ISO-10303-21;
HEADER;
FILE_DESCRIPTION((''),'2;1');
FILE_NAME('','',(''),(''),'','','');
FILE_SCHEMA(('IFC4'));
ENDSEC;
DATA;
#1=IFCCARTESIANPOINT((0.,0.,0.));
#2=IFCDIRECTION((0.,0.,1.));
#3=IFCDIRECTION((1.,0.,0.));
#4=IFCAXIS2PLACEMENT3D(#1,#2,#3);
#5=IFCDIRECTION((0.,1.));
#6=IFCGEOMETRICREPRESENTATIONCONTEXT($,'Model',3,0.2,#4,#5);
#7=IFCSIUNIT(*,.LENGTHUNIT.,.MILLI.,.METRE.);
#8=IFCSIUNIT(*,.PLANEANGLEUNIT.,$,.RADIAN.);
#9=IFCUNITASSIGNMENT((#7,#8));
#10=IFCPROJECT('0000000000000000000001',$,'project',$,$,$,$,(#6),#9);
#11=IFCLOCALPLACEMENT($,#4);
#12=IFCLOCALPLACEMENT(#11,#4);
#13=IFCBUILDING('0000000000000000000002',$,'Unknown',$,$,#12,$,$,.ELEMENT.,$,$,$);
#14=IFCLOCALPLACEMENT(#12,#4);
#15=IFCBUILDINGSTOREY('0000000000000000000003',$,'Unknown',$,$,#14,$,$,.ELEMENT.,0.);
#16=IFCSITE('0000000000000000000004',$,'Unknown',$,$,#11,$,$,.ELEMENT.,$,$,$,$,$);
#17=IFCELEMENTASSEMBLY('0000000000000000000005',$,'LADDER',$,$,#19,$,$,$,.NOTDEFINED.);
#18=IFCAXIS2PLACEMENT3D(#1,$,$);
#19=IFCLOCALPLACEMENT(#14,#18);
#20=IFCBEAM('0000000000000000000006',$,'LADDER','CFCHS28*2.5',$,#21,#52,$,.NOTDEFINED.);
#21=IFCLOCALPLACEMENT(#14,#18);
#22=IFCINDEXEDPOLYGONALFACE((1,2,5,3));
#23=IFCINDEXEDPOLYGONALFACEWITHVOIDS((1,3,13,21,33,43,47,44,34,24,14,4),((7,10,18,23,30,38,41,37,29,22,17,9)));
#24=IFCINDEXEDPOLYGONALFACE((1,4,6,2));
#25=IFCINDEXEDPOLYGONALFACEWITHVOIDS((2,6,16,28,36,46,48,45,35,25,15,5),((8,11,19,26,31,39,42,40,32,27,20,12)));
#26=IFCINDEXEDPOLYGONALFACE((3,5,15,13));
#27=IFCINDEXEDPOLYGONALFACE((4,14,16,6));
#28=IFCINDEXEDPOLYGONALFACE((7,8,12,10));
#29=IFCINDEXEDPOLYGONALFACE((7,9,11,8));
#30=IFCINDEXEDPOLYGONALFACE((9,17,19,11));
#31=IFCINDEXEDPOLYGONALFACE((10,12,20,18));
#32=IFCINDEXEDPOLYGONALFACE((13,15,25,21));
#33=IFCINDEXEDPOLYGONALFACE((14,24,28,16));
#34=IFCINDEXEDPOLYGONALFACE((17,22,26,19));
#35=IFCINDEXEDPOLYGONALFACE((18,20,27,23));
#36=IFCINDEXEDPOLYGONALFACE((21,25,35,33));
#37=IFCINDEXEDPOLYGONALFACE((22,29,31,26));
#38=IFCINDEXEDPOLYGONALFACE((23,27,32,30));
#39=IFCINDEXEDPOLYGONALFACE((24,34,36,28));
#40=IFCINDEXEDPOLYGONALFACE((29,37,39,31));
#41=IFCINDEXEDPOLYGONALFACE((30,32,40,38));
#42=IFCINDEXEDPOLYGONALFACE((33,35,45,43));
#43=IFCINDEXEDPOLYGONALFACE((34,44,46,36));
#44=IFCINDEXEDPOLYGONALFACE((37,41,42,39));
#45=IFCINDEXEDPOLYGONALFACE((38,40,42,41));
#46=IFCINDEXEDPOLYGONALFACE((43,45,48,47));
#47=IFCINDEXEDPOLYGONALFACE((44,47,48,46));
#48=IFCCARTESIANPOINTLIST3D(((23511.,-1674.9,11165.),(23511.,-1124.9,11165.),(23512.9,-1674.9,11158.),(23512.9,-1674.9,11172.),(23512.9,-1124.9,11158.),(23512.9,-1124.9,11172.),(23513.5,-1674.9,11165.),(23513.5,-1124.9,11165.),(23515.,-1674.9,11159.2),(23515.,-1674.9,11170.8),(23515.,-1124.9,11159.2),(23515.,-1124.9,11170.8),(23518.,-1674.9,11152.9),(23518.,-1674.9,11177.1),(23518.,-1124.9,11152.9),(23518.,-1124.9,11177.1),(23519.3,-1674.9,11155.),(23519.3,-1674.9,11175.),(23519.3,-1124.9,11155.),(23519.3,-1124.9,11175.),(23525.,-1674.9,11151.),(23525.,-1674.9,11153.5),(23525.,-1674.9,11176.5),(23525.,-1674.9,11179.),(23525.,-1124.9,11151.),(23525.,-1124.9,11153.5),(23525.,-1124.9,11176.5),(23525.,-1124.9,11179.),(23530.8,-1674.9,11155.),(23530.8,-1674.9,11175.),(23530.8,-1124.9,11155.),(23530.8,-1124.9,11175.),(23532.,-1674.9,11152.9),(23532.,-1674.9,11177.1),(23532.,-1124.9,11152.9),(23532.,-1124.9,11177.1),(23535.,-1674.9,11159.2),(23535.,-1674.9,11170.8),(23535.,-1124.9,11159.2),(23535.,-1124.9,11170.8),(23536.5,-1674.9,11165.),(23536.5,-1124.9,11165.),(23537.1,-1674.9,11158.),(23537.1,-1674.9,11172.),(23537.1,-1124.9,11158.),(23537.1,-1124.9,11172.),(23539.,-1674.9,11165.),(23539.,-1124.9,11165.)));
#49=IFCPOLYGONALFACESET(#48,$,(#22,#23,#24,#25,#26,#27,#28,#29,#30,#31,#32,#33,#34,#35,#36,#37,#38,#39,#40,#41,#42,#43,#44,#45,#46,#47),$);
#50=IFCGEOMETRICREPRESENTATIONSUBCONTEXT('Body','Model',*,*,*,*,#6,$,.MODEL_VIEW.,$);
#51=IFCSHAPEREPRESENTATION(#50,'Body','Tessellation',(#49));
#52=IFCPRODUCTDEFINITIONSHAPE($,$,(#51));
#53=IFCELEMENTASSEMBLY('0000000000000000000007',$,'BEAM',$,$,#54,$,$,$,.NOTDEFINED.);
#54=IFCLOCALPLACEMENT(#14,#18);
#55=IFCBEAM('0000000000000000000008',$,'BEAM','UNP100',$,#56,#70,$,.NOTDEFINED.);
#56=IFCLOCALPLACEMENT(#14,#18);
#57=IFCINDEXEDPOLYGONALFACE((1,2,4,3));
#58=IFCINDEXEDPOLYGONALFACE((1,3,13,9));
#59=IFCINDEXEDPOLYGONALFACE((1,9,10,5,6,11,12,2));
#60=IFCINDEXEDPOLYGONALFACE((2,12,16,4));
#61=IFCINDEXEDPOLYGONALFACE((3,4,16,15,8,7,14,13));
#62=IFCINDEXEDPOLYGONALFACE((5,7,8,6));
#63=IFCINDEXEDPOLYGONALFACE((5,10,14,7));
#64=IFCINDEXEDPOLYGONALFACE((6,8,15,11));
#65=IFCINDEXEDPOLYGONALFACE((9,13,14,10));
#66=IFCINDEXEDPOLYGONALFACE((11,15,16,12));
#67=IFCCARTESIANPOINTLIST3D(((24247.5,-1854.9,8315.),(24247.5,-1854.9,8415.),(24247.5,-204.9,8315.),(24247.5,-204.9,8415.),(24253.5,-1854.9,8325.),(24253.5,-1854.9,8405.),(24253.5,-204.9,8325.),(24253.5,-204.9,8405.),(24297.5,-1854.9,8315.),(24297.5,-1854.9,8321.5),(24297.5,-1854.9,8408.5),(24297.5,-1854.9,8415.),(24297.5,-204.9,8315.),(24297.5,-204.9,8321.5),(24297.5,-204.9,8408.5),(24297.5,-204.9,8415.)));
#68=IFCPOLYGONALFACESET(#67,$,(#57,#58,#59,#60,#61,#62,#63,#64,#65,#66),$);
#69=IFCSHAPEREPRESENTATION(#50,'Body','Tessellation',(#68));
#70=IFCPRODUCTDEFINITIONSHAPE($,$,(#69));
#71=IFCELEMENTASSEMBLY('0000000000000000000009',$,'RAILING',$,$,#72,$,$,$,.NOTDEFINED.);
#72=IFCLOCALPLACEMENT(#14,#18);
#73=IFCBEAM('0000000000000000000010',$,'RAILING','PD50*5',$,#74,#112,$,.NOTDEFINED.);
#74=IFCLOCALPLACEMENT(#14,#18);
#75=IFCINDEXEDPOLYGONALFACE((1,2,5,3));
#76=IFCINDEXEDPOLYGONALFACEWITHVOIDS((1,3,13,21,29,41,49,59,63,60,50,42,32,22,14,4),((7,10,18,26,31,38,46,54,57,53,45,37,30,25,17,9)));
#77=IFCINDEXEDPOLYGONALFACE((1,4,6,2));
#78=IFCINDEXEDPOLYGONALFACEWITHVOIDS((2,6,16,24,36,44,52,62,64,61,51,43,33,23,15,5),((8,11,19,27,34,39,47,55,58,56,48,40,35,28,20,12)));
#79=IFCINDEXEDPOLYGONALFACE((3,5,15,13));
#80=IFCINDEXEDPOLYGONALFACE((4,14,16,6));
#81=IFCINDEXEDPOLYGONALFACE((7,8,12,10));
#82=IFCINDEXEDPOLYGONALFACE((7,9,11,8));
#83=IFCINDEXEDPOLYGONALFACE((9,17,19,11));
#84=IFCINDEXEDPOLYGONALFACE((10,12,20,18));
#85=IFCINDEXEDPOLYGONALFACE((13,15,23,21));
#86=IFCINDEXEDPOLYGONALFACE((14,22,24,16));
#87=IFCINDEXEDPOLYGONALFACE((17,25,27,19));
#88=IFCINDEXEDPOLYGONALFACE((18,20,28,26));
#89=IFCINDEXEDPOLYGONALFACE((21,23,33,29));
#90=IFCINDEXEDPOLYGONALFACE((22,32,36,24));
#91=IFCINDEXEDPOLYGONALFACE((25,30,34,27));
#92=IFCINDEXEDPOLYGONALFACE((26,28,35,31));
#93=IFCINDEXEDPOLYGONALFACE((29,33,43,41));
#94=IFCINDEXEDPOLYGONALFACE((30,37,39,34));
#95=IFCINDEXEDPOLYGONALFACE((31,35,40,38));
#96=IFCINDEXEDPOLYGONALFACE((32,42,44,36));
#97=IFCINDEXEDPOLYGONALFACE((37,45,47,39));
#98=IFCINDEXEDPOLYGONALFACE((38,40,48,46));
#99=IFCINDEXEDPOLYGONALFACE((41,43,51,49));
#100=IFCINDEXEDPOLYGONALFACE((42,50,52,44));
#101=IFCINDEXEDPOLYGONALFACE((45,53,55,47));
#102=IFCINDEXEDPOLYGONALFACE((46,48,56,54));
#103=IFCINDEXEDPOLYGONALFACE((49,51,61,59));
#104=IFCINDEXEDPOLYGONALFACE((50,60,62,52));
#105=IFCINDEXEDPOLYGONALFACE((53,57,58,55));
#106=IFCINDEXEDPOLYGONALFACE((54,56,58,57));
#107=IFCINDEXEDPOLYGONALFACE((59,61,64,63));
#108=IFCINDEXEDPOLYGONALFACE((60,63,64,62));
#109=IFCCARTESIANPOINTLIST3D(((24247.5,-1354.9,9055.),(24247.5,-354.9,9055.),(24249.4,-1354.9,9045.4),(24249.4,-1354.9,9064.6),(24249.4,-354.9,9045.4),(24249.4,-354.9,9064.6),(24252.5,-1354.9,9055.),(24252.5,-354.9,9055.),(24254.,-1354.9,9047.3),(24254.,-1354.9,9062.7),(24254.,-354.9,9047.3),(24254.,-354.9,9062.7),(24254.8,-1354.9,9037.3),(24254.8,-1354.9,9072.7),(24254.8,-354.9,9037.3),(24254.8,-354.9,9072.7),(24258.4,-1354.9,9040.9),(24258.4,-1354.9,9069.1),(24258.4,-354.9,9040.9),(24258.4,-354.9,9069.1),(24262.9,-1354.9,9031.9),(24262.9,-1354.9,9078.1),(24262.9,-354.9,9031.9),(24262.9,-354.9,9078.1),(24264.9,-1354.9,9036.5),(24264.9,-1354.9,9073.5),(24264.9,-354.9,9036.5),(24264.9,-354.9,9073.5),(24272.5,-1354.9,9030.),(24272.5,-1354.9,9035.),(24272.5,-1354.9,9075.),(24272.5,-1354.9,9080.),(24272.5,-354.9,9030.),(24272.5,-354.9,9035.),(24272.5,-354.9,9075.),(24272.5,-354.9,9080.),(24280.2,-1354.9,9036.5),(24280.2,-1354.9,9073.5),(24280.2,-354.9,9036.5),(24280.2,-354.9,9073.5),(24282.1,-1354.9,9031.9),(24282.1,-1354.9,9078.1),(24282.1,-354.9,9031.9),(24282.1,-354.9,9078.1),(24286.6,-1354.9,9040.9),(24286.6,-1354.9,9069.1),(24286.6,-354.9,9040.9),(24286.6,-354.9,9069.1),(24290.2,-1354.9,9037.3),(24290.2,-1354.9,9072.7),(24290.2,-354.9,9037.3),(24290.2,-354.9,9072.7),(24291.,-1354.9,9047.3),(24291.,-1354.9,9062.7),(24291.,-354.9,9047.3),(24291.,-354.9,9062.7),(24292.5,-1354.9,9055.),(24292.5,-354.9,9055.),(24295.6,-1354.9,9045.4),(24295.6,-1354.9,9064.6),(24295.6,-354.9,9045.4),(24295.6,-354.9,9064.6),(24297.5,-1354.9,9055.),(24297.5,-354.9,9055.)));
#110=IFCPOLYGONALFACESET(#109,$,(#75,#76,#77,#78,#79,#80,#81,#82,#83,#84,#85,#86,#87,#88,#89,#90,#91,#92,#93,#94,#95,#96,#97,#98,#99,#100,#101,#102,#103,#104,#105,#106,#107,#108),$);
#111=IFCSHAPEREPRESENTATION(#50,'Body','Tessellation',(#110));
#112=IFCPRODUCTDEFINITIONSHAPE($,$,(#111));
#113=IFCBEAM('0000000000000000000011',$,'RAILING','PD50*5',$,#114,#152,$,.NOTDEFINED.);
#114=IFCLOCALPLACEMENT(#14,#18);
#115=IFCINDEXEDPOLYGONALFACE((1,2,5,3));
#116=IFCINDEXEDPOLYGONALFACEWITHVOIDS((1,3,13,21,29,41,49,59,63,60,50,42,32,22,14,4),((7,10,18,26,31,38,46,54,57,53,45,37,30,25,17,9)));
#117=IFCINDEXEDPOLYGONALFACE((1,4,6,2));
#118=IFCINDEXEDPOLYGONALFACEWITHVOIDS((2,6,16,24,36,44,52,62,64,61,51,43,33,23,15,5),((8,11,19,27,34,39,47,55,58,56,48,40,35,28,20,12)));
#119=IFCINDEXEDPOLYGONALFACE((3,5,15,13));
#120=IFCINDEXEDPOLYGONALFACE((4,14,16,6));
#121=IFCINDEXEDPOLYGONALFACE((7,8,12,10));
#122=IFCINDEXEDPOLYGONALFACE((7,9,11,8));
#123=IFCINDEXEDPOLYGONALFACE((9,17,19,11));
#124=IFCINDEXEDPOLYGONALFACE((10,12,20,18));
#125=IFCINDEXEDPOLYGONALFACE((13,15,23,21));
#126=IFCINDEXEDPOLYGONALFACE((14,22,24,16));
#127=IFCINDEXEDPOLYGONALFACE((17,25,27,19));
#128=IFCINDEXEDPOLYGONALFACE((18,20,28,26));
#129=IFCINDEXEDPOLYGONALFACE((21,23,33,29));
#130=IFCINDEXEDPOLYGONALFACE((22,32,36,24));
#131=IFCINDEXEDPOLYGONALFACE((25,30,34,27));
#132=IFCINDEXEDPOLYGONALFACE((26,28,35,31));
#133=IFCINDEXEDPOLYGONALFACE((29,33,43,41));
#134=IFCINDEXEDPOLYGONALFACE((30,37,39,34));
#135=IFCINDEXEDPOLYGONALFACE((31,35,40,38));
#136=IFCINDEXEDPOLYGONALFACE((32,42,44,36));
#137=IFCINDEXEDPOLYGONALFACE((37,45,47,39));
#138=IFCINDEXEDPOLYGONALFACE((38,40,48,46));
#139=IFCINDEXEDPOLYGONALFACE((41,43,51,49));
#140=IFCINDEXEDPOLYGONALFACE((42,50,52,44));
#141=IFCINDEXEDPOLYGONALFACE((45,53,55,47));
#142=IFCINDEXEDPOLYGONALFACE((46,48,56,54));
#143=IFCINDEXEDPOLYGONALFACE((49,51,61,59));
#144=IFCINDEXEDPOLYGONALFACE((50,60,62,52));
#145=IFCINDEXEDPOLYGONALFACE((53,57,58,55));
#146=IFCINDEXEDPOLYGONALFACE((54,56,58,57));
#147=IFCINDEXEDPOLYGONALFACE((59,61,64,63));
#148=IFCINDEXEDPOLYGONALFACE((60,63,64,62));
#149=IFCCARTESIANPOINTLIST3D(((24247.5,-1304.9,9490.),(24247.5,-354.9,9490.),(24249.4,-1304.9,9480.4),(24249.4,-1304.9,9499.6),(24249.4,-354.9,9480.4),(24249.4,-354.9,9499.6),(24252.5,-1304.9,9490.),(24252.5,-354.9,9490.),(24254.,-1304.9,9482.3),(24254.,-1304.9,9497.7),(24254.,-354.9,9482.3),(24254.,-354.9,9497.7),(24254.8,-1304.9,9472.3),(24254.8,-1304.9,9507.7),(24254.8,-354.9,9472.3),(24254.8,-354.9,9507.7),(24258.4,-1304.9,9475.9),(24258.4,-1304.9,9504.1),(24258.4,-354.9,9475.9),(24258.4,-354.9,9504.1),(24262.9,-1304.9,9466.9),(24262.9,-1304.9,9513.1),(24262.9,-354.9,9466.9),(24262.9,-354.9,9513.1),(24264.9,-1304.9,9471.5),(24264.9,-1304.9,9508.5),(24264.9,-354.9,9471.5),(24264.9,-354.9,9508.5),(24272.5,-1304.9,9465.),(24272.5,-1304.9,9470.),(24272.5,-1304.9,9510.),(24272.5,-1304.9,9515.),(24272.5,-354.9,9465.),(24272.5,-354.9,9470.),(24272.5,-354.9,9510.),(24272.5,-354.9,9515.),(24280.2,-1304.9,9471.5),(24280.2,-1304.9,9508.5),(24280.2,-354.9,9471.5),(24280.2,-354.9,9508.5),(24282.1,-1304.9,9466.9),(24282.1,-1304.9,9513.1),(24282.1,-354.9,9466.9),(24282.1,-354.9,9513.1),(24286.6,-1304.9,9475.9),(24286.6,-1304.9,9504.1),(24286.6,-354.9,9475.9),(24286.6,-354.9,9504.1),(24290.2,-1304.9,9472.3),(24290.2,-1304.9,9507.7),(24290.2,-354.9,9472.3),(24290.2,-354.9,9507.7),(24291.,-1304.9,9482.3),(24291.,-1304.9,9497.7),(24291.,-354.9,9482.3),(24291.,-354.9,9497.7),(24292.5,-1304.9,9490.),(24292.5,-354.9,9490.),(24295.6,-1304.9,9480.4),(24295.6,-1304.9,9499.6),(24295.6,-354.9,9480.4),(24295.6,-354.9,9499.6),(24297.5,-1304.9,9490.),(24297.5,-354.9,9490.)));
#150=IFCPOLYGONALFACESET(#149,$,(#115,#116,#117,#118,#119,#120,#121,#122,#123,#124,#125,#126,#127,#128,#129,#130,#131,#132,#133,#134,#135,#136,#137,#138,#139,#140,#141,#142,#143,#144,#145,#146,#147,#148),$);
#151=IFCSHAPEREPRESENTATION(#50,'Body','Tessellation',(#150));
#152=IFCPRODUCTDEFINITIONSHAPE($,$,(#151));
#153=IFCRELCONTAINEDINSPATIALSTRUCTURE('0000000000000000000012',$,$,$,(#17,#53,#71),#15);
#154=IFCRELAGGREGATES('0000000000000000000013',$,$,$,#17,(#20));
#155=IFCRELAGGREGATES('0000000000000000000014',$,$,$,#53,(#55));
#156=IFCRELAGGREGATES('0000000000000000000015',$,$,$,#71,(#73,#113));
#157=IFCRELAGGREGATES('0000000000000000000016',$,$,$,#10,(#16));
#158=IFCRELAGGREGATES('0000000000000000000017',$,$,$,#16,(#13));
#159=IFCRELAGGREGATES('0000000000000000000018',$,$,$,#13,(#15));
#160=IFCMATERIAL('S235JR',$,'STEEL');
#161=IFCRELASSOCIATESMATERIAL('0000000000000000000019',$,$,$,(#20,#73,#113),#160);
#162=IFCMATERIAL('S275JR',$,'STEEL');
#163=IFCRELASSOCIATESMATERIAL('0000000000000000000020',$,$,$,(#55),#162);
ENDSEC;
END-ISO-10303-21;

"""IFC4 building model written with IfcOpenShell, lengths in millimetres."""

from ifc_helpers import new_model, si_unit, direction, frame, origin_with_axes, place, context, subcontext, project, spatial, line, indexed_curve, outline, extrude, material, element, aggregate, save


model = new_model("IFC4")

# Units and contexts
model_context = context("Model", 3, precision=0.2, world=origin_with_axes(), true_north=direction((0.0, 1.0)))
body_context = subcontext(model_context, "Body", "Model", "MODEL_VIEW")
ifc_project = project(units=[si_unit("LENGTHUNIT", "METRE", prefix="MILLI"), si_unit("PLANEANGLEUNIT", "RADIAN")], contexts=[model_context])

# Site, building, storey
site_placement = place(None, origin_with_axes())
site = spatial("IfcSite", under=ifc_project, at=site_placement, Name="Unknown", CompositionType="ELEMENT")
building_placement = place(site_placement, origin_with_axes())
building = spatial("IfcBuilding", under=site, at=building_placement, Name="Unknown", CompositionType="ELEMENT")
storey_placement = place(building_placement, origin_with_axes())
storey = spatial("IfcBuildingStorey", under=building, at=storey_placement, Name="Unknown", CompositionType="ELEMENT", Elevation=0.0)

# Element assembly, beam
assembly_1_placement = place(storey_placement, frame((23525.0, -1699.9, 5175.0), z_axis=(0.0, 1.0, 0.0), x_axis=(0.0, 0.0, 1.0)))
assembly_1 = element("IfcElementAssembly", 1, at=assembly_1_placement, inside=storey, Name="LADDER", PredefinedType="NOTDEFINED")
ifc_material_1 = material(Name="S275JR", Category="STEEL")
ifc_material_2 = material(Name="S235JR", Category="STEEL")
beam_1_placement = place(assembly_1_placement, frame((5990.0, 0.0, 25.0), z_axis=(0.0, -1.0, 0.0), x_axis=(0.0, 0.0, 1.0)))
beam_1 = element("IfcBeam", 2, at=beam_1_placement, material=ifc_material_2, Name="LADDER", Description="CFCHS28*2.5", PredefinedType="NOTDEFINED", context=body_context, shape_type="SolidModel", body=[
    extrude(outline(indexed_curve([(14.0, 0.0), (12.1, 7.0), (7.0, 12.1), (0.0, 14.0), (-7.0, 12.1), (-12.1, 7.0), (-14.0, 0.0), (-12.1, -7.0), (-7.0, -12.1), (0.0, -14.0), (7.0, -12.1), (12.1, -7.0)], segments=[line(1, 2, 3, 4, 5, 6, 7, 8, 9, 10, 11, 12, 1)]), holes=[indexed_curve([(11.5, 0.0), (10.0, -5.8), (5.8, -10.0), (0.0, -11.5), (-5.8, -10.0), (-10.0, -5.8), (-11.5, 0.0), (-10.0, 5.8), (-5.8, 10.0), (0.0, 11.5), (5.8, 10.0), (10.0, 5.8)], segments=[line(1, 2, 3, 4, 5, 6, 7, 8, 9, 10, 11, 12, 1)])]), frame((0.0, 0.0, 0.0), z_axis=(-1.0, 0.0, 0.0), x_axis=(0.0, 0.0, 1.0)), (0.0, 0.0, -1.0), 550.0),
])

# Element assembly, beam
assembly_2_placement = place(storey_placement, frame((24272.5, -204.9, 8365.0), z_axis=(1.0, 0.0, 0.0), x_axis=(0.0, -1.0, 0.0)))
assembly_2 = element("IfcElementAssembly", 3, at=assembly_2_placement, inside=storey, Name="BEAM", PredefinedType="NOTDEFINED")
beam_2_placement = place(assembly_2_placement, origin_with_axes())
beam_2 = element("IfcBeam", 4, at=beam_2_placement, material=ifc_material_1, Name="BEAM", Description="UNP100", PredefinedType="NOTDEFINED", context=body_context, shape_type="SolidModel", body=[
    extrude(outline(indexed_curve([(-25.0, -50.0), (25.0, -50.0), (25.0, -43.5), (-19.0, -40.0), (-19.0, 40.0), (25.0, 43.5), (25.0, 50.0), (-25.0, 50.0)], segments=[line(1, 2, 3, 4, 5, 6, 7, 8, 1)])), frame((0.0, 0.0, 0.0), z_axis=(-1.0, 0.0, 0.0), x_axis=(0.0, 0.0, 1.0)), (0.0, 0.0, -1.0), 1650.0),
])

# Element assembly, beams
assembly_3_placement = place(storey_placement, frame((24272.5, -1304.9, 9490.0), z_axis=(-1.0, 0.0, 0.0), x_axis=(0.0, 1.0, 0.0)))
assembly_3 = element("IfcElementAssembly", 5, at=assembly_3_placement, inside=storey, Name="RAILING", PredefinedType="NOTDEFINED")
beam_3_placement = place(assembly_3_placement, frame((-50.0, 435.0, 0.0), z_axis=(0.0, -1.0, 0.0), x_axis=(1.0, 0.0, 0.0)))
beam_3 = element("IfcBeam", 6, at=beam_3_placement, material=ifc_material_2, Name="RAILING", Description="PD50*5", PredefinedType="NOTDEFINED", context=body_context, shape_type="SolidModel", body=[
    extrude(outline(indexed_curve([(25.0, 0.0), (23.1, 9.6), (17.7, 17.7), (9.6, 23.1), (0.0, 25.0), (-9.6, 23.1), (-17.7, 17.7), (-23.1, 9.6), (-25.0, 0.0), (-23.1, -9.6), (-17.7, -17.7), (-9.6, -23.1), (0.0, -25.0), (9.6, -23.1), (17.7, -17.7), (23.1, -9.6)], segments=[line(1, 2, 3, 4, 5, 6, 7, 8, 9, 10, 11, 12, 13, 14, 15, 16, 1)]), holes=[indexed_curve([(20.0, 0.0), (18.5, -7.7), (14.1, -14.1), (7.7, -18.5), (0.0, -20.0), (-7.7, -18.5), (-14.1, -14.1), (-18.5, -7.7), (-20.0, 0.0), (-18.5, 7.7), (-14.1, 14.1), (-7.7, 18.5), (0.0, 20.0), (7.7, 18.5), (14.1, 14.1), (18.5, 7.7)], segments=[line(1, 2, 3, 4, 5, 6, 7, 8, 9, 10, 11, 12, 13, 14, 15, 16, 1)])]), frame((0.0, 0.0, 0.0), z_axis=(-1.0, 0.0, 0.0), x_axis=(0.0, 0.0, 1.0)), (0.0, 0.0, -1.0), 1000.0),
])
beam_4_placement = place(assembly_3_placement, origin_with_axes())
beam_4 = element("IfcBeam", 7, at=beam_4_placement, material=ifc_material_2, Name="RAILING", Description="PD50*5", PredefinedType="NOTDEFINED", context=body_context, shape_type="SolidModel", body=[
    extrude(outline(indexed_curve([(25.0, 0.0), (23.1, 9.6), (17.7, 17.7), (9.6, 23.1), (0.0, 25.0), (-9.6, 23.1), (-17.7, 17.7), (-23.1, 9.6), (-25.0, 0.0), (-23.1, -9.6), (-17.7, -17.7), (-9.6, -23.1), (0.0, -25.0), (9.6, -23.1), (17.7, -17.7), (23.1, -9.6)], segments=[line(1, 2, 3, 4, 5, 6, 7, 8, 9, 10, 11, 12, 13, 14, 15, 16, 1)]), holes=[indexed_curve([(20.0, 0.0), (18.5, -7.7), (14.1, -14.1), (7.7, -18.5), (0.0, -20.0), (-7.7, -18.5), (-14.1, -14.1), (-18.5, -7.7), (-20.0, 0.0), (-18.5, 7.7), (-14.1, 14.1), (-7.7, 18.5), (0.0, 20.0), (7.7, 18.5), (14.1, 14.1), (18.5, 7.7)], segments=[line(1, 2, 3, 4, 5, 6, 7, 8, 9, 10, 11, 12, 13, 14, 15, 16, 1)])]), frame((0.0, 0.0, 0.0), z_axis=(-1.0, 0.0, 0.0), x_axis=(0.0, 0.0, 1.0)), (0.0, 0.0, -1.0), 950.0),
])

aggregate(assembly_1, [beam_1])
aggregate(assembly_2, [beam_2])
aggregate(assembly_3, [beam_3, beam_4])

save(model, "model.ifc")
